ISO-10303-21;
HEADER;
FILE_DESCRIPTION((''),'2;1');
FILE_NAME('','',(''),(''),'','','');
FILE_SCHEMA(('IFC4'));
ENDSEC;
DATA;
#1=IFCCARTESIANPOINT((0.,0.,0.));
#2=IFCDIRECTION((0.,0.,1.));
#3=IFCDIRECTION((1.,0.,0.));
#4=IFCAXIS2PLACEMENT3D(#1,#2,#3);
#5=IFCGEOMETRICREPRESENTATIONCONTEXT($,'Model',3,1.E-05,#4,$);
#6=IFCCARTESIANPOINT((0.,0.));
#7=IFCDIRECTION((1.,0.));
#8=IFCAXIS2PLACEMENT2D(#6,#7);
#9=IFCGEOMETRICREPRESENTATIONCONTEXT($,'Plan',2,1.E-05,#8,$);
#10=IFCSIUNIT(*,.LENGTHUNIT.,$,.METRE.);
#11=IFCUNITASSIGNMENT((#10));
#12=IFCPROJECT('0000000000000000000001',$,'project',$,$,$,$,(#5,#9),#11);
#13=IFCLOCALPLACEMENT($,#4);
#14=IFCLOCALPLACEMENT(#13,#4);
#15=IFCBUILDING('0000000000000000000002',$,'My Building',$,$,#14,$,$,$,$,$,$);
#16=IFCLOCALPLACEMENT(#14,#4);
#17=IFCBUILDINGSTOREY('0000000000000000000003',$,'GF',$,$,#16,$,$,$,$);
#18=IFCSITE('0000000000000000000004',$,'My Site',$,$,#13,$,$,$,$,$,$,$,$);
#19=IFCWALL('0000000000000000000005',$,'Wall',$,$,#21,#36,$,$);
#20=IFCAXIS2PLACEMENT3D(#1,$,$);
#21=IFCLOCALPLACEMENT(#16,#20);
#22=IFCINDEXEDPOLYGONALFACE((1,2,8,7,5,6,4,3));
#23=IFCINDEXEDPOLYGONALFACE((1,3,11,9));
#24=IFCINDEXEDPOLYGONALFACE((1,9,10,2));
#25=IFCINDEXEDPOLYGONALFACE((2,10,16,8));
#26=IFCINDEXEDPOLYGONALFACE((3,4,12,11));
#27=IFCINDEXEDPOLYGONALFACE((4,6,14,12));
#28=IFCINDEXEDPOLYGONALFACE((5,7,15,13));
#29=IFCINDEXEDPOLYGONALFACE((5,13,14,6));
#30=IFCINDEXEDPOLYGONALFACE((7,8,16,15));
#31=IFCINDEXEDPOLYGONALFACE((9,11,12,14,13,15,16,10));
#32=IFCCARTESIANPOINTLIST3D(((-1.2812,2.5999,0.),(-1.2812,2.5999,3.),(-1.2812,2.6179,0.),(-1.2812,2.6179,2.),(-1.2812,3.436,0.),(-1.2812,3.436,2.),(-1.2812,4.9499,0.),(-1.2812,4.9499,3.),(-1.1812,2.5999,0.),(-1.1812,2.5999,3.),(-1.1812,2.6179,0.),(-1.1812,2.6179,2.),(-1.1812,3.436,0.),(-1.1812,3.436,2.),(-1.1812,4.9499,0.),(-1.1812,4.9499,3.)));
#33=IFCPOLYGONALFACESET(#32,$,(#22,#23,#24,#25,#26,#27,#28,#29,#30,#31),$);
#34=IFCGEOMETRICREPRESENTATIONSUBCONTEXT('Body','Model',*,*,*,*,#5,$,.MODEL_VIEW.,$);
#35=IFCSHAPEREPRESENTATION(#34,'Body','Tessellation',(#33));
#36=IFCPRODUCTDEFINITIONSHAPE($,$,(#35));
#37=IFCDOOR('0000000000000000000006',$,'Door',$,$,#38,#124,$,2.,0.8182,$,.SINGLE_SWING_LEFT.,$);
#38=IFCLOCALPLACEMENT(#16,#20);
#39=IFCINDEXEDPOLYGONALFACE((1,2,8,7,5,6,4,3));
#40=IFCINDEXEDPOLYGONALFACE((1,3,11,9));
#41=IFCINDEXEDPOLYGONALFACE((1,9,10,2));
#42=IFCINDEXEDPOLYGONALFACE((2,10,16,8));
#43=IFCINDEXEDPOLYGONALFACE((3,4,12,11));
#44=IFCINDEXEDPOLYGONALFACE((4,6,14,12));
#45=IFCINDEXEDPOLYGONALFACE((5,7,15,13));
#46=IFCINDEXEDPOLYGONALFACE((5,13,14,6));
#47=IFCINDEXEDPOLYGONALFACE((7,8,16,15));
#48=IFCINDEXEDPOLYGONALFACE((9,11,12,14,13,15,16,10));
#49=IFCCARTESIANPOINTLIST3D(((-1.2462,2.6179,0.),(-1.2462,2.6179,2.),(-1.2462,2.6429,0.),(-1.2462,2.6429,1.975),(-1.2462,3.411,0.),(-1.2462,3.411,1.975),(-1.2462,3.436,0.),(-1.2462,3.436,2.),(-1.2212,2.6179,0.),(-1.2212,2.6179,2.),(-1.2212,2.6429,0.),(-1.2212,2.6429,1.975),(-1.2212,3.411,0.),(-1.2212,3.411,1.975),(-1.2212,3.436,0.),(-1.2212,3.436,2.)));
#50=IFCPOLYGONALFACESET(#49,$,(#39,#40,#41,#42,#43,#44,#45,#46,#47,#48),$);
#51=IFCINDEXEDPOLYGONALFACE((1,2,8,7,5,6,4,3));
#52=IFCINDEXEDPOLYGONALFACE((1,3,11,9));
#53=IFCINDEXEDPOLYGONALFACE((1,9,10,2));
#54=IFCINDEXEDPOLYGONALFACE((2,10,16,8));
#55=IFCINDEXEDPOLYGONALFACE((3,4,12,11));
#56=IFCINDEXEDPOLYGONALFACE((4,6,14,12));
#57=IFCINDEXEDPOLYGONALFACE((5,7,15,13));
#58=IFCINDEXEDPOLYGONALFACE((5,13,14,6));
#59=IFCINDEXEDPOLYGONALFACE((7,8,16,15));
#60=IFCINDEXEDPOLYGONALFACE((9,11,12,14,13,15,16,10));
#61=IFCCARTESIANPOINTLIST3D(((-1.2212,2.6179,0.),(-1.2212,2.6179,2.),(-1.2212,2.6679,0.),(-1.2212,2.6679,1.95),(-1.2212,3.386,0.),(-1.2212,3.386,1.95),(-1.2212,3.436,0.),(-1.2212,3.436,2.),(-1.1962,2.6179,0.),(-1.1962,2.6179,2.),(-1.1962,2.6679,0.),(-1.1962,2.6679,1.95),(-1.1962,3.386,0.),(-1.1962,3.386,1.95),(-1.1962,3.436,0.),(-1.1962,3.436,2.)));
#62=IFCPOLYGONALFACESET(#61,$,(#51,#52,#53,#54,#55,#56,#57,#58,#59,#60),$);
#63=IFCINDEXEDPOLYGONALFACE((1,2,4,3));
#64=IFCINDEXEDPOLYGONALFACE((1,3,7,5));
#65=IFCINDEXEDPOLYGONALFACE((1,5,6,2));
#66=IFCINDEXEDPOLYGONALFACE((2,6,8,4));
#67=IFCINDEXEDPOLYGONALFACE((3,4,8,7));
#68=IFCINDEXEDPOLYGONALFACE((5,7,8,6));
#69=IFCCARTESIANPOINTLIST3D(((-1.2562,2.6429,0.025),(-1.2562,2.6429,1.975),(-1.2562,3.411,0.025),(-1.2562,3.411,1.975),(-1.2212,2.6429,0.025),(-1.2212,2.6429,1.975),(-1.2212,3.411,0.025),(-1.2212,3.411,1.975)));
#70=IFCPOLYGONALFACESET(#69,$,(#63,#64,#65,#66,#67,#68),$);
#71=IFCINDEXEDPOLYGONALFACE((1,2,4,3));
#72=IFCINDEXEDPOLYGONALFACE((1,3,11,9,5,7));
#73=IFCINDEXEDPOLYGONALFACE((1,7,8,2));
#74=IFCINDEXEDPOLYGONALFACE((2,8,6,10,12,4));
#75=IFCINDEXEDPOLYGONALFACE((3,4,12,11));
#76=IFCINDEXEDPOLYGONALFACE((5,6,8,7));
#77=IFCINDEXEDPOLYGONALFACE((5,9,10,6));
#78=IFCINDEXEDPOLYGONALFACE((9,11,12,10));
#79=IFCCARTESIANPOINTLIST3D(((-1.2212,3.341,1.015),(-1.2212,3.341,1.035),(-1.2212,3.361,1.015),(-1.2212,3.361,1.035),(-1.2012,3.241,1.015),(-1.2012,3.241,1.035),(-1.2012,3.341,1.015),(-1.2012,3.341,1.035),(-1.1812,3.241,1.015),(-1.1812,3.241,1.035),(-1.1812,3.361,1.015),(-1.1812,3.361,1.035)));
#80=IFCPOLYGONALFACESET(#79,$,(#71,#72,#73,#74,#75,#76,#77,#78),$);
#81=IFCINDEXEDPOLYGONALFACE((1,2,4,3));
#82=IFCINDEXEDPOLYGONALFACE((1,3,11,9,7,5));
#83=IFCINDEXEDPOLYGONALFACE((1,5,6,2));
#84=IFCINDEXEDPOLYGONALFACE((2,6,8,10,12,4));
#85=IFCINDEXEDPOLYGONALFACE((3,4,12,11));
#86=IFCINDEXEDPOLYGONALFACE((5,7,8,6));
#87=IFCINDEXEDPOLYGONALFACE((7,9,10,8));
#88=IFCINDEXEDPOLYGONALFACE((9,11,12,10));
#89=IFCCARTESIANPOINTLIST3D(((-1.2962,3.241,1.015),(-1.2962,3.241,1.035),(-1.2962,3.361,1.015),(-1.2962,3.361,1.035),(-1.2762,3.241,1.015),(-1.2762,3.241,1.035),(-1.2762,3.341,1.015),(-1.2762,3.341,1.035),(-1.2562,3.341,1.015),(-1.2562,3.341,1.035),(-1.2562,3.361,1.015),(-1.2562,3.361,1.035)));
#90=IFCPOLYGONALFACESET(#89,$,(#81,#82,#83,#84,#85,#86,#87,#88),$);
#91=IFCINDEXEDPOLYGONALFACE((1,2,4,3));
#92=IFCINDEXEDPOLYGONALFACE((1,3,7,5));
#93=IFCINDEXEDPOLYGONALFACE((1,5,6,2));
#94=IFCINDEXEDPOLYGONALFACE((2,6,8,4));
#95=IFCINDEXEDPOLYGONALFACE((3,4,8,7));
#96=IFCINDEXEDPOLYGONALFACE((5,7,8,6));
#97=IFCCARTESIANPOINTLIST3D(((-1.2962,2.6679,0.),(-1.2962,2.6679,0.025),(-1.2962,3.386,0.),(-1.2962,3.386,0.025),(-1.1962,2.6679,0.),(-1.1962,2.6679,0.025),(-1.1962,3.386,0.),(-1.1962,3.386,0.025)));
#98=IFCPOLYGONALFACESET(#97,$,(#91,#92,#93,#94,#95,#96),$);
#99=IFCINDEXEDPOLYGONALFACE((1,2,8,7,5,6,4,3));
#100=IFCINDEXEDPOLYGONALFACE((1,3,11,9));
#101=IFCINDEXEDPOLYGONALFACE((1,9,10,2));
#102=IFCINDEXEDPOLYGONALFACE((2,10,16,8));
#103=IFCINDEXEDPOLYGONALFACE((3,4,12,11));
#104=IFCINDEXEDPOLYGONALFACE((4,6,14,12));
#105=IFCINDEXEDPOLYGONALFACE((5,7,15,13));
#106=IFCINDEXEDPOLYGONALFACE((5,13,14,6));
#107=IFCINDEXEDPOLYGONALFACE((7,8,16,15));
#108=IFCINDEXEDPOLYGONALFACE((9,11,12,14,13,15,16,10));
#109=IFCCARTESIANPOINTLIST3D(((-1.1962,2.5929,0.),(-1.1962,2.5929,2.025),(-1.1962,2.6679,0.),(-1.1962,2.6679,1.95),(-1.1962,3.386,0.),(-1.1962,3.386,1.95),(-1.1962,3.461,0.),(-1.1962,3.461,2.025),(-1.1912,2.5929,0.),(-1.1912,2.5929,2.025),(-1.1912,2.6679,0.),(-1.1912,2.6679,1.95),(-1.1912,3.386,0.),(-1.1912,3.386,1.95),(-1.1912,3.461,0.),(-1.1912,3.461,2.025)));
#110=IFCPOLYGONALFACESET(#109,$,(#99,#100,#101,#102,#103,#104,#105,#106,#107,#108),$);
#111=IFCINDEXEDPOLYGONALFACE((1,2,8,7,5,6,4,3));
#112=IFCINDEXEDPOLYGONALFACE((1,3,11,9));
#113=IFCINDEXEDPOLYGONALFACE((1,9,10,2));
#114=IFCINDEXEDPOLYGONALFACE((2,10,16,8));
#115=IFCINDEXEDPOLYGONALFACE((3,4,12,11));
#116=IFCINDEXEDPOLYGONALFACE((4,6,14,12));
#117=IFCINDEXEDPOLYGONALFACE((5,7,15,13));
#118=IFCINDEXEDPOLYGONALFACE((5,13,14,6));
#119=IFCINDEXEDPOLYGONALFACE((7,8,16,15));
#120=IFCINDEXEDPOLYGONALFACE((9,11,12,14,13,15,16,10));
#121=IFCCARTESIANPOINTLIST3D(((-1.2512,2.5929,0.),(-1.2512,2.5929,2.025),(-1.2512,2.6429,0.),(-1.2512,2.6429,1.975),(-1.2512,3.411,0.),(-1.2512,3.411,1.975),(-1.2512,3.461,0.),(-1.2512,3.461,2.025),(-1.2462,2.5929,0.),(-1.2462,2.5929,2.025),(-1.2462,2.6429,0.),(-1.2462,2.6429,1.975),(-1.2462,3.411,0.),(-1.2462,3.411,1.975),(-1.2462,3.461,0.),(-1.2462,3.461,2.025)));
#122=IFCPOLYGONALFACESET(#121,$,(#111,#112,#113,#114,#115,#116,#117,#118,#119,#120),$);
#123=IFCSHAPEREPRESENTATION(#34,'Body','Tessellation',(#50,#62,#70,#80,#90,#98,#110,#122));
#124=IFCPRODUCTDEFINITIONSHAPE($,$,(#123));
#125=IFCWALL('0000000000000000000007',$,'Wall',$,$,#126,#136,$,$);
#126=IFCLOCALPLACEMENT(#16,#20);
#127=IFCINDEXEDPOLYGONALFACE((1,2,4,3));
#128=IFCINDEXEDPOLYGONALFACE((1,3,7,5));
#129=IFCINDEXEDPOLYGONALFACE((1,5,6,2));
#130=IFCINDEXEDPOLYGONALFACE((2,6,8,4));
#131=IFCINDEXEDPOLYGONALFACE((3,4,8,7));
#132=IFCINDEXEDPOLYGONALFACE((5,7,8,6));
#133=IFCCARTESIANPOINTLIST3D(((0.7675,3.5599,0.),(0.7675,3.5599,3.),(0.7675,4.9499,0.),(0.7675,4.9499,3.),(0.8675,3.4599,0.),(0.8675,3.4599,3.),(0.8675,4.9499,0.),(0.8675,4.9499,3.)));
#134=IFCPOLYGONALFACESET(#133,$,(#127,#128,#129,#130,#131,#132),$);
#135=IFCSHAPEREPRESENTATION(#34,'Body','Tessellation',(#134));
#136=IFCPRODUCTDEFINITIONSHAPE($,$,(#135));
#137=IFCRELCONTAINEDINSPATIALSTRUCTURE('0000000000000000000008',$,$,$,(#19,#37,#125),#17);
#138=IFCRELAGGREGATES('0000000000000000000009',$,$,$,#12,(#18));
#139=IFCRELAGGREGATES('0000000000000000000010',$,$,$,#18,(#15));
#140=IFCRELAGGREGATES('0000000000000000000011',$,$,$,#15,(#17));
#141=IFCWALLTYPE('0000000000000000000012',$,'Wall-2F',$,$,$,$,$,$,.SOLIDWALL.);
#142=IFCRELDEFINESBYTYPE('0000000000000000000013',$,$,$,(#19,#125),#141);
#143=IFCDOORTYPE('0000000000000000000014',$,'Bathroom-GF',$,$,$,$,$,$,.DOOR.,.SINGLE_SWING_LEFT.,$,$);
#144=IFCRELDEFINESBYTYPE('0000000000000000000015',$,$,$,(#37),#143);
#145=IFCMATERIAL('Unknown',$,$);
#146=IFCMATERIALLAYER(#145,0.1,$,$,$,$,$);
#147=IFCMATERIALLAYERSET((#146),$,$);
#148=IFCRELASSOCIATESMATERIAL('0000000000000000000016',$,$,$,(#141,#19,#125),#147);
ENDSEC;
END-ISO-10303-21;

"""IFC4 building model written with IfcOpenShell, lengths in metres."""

from ifc_helpers import new_model, entity, si_unit, frame, origin_with_axes, origin_2d_with_axis, place, context, subcontext, project, spatial, line, indexed_curve, outline, extrude, shape, source, transform, mapped, material, layer, layer_set, layer_usage, type_object, type_shapes, element, fill, save


model = new_model("IFC4")

# Units and contexts
model_context = context("Model", 3, precision=1e-05, world=origin_with_axes())
plan_context = context("Plan", 2, precision=1e-05, world=origin_2d_with_axis())
body_context_1 = subcontext(model_context, "Body", "Model", "MODEL_VIEW")
body_context_2 = subcontext(plan_context, "Body", "Plan", "PLAN_VIEW")
ifc_project = project(units=[si_unit("LENGTHUNIT", "METRE")], contexts=[model_context, plan_context])

# Site, building, storey
site_placement = place(None, origin_with_axes())
site = spatial("IfcSite", under=ifc_project, at=site_placement, Name="My Site")
building_placement = place(site_placement, origin_with_axes())
building = spatial("IfcBuilding", under=site, at=building_placement, Name="My Building")
storey_placement = place(building_placement, origin_with_axes())
storey = spatial("IfcBuildingStorey", under=building, at=storey_placement, Name="GF")

# Shared definitions
ifc_material = material(Name="Unknown")

# Shared definitions
ifc_layer_1 = layer(ifc_material, 0.1)
ifc_layer_set_1 = layer_set([ifc_layer_1])
wall_type = type_object("IfcWallType", Name="Wall-2F", PredefinedType="SOLIDWALL", material=ifc_layer_set_1)

# Wall, opening, door
ifc_layer_usage_1 = layer_usage(ifc_layer_set_1, "AXIS2", "POSITIVE", 0.0)
wall_1_placement = place(storey_placement, frame((-1.1812, 2.5999, 0.0), z_axis=(0.0, 0.0, 1.0), x_axis=(0.0, 1.0, 0.0)))
wall_1 = element("IfcWall", 1, at=wall_1_placement, inside=storey, type_object=wall_type, material=ifc_layer_usage_1, Name="Wall", context=body_context_1, shape_type="SweptSolid", body=[
    extrude(outline(indexed_curve([(0.0, 0.0), (0.0, 0.1), (2.35, 0.1), (2.35, 0.0)], segments=[line(1, 2, 3, 4, 1)])), origin_with_axes(), (0.0, 0.0, 1.0), 3.0),
])
shared_shape_1 = source(origin_with_axes(), body_context_1, "Body", "SweptSolid", [
    extrude(outline(indexed_curve([(0.0, 0.0), (0.8182, 0.0), (0.8182, 2.0), (0.0, 2.0)], segments=[line(1, 2, 3, 4, 1)])), frame((0.0, -0.6, 0.0), z_axis=(0.0, -1.0, 0.0), x_axis=(1.0, 0.0, 0.0)), (0.0, 0.0, -1.0), 1.2),
])
opening_1_placement = place(wall_1_placement, frame((0.0179, 0.015, 0.0), z_axis=(0.0, 0.0, 1.0), x_axis=(1.0, 0.0, 0.0)))
opening_1 = element("IfcOpeningElement", 2, at=opening_1_placement, cuts=wall_1, PredefinedType="OPENING", context=body_context_1, shape_type="MappedRepresentation", body=[
    mapped(shared_shape_1, transform((0.0, 0.0, 0.0), x_axis=(1.0, 0.0, 0.0), y_axis=(0.0, 1.0, 0.0), z_axis=(0.0, 0.0, 1.0), scale=1.0)),
])
door_type_1 = type_object("IfcDoorType", Name="Bathroom-GF", OperationType="SINGLE_SWING_LEFT", PredefinedType="DOOR")
shared_shape_2 = source(origin_with_axes(), body_context_1, "Body", "SweptSolid", [
    extrude(outline(indexed_curve([(0.0, 0.0), (0.0, 2.0), (0.8182, 2.0), (0.8182, 0.0), (0.7932, 0.0), (0.7932, 1.975), (0.025, 1.975), (0.025, 0.0)], segments=[line(1, 2, 3, 4, 5, 6, 7, 8, 1)])), frame((0.0, 0.025, 0.0), z_axis=(0.0, -1.0, 0.0), x_axis=(1.0, 0.0, 0.0)), (0.0, 0.0, -1.0), 0.025),
    extrude(outline(indexed_curve([(0.0, 0.0), (0.0, 2.0), (0.8182, 2.0), (0.8182, 0.0), (0.7682, 0.0), (0.7682, 1.95), (0.05, 1.95), (0.05, 0.0)], segments=[line(1, 2, 3, 4, 5, 6, 7, 8, 1)])), frame((0.0, 0.0, 0.0), z_axis=(0.0, -1.0, 0.0), x_axis=(1.0, 0.0, 0.0)), (0.0, 0.0, -1.0), 0.025),
    extrude(outline(indexed_curve([(0.0, 0.0), (0.7682, 0.0), (0.7682, 0.035), (0.0, 0.035)], segments=[line(1, 2, 3, 4, 1)])), frame((0.025, 0.025, 0.025), z_axis=(0.0, 0.0, 1.0), x_axis=(1.0, 0.0, 0.0)), (0.0, 0.0, 1.0), 1.95),
    extrude(outline(indexed_curve([(0.0, 0.0), (0.0, -0.04), (-0.12, -0.04), (-0.12, -0.02), (-0.02, -0.02), (-0.02, 0.0)], segments=[line(1, 2, 3, 4, 5, 6, 1)])), frame((0.7432, 0.025, 1.015), z_axis=(0.0, 0.0, 1.0), x_axis=(1.0, 0.0, 0.0)), (0.0, 0.0, 1.0), 0.02),
    extrude(outline(indexed_curve([(0.0, 0.0), (0.0, 0.04), (-0.12, 0.04), (-0.12, 0.02), (-0.02, 0.02), (-0.02, 0.0)], segments=[line(1, 2, 3, 4, 5, 6, 1)])), frame((0.7432, 0.06, 1.015), z_axis=(0.0, 0.0, 1.0), x_axis=(1.0, 0.0, 0.0)), (0.0, 0.0, 1.0), 0.02),
    extrude(outline(indexed_curve([(0.0, 0.0), (0.7182, 0.0), (0.7182, 0.1), (0.0, 0.1)], segments=[line(1, 2, 3, 4, 1)])), frame((0.05, 0.0, 0.0), z_axis=(0.0, 0.0, 1.0), x_axis=(1.0, 0.0, 0.0)), (0.0, 0.0, 1.0), 0.025),
    extrude(outline(indexed_curve([(0.0, 0.0), (0.0, 2.025), (0.8682, 2.025), (0.8682, 0.0), (0.7932, 0.0), (0.7932, 1.95), (0.075, 1.95), (0.075, 0.0)], segments=[line(1, 2, 3, 4, 5, 6, 7, 8, 1)])), frame((-0.025, -0.005, 0.0), z_axis=(0.0, -1.0, 0.0), x_axis=(1.0, 0.0, 0.0)), (0.0, 0.0, -1.0), 0.005),
    extrude(outline(indexed_curve([(0.0, 0.0), (0.0, 2.025), (0.8682, 2.025), (0.8682, 0.0), (0.8182, 0.0), (0.8182, 1.975), (0.05, 1.975), (0.05, 0.0)], segments=[line(1, 2, 3, 4, 5, 6, 7, 8, 1)])), frame((-0.025, 0.05, 0.0), z_axis=(0.0, -1.0, 0.0), x_axis=(1.0, 0.0, 0.0)), (0.0, 0.0, -1.0), 0.005),
])
shared_shape_3 = source(origin_with_axes(), body_context_2, "Body", "Curve2D", [
    entity("IfcIndexedPolyCurve", entity("IfcCartesianPointList2D", [[0.0, 0.0], [0.0, 0.05], [0.025, 0.05], [0.025, 0.025], [0.05, 0.025], [0.05, 0.0]]), [entity("IfcLineIndex", [1, 2, 3, 4, 5, 6, 1])]),
    entity("IfcIndexedPolyCurve", entity("IfcCartesianPointList2D", [[0.8182, 0.0], [0.8182, 0.05], [0.7932, 0.05], [0.7932, 0.025], [0.7682, 0.025], [0.7682, 0.0]]), [entity("IfcLineIndex", [1, 2, 3, 4, 5, 6, 1])]),
    entity("IfcTrimmedCurve", entity("IfcEllipse", entity("IfcAxis2Placement2D", entity("IfcCartesianPoint", [0.06, 0.05]), entity("IfcDirection", [1.0, 0.0])), 0.7332, 0.7682), [entity("IfcCartesianPoint", [0.7932, 0.05])], [entity("IfcCartesianPoint", [0.06, 0.8182])], True, "CARTESIAN"),
    entity("IfcIndexedPolyCurve", entity("IfcCartesianPointList2D", [[0.025, 0.05], [0.06, 0.05], [0.06, 0.8182], [0.025, 0.8182]]), [entity("IfcLineIndex", [1, 2, 3, 4, 1])]),
])
type_shapes(door_type_1, [shared_shape_2, shared_shape_3])
door_1_placement = place(opening_1_placement, frame((0.0, 0.0, 0.0), z_axis=(0.0, 0.0, 1.0), x_axis=(1.0, 0.0, 0.0)))
door_1 = element("IfcDoor", 3, at=door_1_placement, inside=storey, type_object=door_type_1, Name="Door", OperationType="SINGLE_SWING_LEFT", OverallHeight=2.0, OverallWidth=0.8182, shapes=[
    shape(body_context_1, "Body", "MappedRepresentation", [mapped(shared_shape_2, transform((0.0, 0.0, 0.0), x_axis=(1.0, 0.0, 0.0), y_axis=(0.0, 1.0, 0.0), z_axis=(0.0, 0.0, 1.0), scale=1.0))]),
    shape(body_context_2, "Body", "MappedRepresentation", [mapped(shared_shape_3, transform((0.0, 0.0, 0.0), x_axis=(1.0, 0.0, 0.0), y_axis=(0.0, 1.0, 0.0), z_axis=(0.0, 0.0, 1.0), scale=1.0))]),
])
fill(opening_1, door_1)

# Wall
ifc_layer_usage_2 = layer_usage(ifc_layer_set_1, "AXIS2", "POSITIVE", 0.0)
wall_2_placement = place(storey_placement, frame((0.7675, 5.0499, 0.0), z_axis=(0.0, 0.0, 1.0), x_axis=(0.0, -1.0, 0.0)))
element("IfcWall", 4, at=wall_2_placement, inside=storey, type_object=wall_type, material=ifc_layer_usage_2, Name="Wall", context=body_context_1, shape_type="SweptSolid", body=[
    extrude(outline(indexed_curve([(0.1, 0.0), (0.1, 0.1), (1.59, 0.1), (1.49, 0.0)], segments=[line(1, 2, 3, 4, 1)])), origin_with_axes(), (0.0, 0.0, 1.0), 3.0),
])

save(model, "model.ifc")
